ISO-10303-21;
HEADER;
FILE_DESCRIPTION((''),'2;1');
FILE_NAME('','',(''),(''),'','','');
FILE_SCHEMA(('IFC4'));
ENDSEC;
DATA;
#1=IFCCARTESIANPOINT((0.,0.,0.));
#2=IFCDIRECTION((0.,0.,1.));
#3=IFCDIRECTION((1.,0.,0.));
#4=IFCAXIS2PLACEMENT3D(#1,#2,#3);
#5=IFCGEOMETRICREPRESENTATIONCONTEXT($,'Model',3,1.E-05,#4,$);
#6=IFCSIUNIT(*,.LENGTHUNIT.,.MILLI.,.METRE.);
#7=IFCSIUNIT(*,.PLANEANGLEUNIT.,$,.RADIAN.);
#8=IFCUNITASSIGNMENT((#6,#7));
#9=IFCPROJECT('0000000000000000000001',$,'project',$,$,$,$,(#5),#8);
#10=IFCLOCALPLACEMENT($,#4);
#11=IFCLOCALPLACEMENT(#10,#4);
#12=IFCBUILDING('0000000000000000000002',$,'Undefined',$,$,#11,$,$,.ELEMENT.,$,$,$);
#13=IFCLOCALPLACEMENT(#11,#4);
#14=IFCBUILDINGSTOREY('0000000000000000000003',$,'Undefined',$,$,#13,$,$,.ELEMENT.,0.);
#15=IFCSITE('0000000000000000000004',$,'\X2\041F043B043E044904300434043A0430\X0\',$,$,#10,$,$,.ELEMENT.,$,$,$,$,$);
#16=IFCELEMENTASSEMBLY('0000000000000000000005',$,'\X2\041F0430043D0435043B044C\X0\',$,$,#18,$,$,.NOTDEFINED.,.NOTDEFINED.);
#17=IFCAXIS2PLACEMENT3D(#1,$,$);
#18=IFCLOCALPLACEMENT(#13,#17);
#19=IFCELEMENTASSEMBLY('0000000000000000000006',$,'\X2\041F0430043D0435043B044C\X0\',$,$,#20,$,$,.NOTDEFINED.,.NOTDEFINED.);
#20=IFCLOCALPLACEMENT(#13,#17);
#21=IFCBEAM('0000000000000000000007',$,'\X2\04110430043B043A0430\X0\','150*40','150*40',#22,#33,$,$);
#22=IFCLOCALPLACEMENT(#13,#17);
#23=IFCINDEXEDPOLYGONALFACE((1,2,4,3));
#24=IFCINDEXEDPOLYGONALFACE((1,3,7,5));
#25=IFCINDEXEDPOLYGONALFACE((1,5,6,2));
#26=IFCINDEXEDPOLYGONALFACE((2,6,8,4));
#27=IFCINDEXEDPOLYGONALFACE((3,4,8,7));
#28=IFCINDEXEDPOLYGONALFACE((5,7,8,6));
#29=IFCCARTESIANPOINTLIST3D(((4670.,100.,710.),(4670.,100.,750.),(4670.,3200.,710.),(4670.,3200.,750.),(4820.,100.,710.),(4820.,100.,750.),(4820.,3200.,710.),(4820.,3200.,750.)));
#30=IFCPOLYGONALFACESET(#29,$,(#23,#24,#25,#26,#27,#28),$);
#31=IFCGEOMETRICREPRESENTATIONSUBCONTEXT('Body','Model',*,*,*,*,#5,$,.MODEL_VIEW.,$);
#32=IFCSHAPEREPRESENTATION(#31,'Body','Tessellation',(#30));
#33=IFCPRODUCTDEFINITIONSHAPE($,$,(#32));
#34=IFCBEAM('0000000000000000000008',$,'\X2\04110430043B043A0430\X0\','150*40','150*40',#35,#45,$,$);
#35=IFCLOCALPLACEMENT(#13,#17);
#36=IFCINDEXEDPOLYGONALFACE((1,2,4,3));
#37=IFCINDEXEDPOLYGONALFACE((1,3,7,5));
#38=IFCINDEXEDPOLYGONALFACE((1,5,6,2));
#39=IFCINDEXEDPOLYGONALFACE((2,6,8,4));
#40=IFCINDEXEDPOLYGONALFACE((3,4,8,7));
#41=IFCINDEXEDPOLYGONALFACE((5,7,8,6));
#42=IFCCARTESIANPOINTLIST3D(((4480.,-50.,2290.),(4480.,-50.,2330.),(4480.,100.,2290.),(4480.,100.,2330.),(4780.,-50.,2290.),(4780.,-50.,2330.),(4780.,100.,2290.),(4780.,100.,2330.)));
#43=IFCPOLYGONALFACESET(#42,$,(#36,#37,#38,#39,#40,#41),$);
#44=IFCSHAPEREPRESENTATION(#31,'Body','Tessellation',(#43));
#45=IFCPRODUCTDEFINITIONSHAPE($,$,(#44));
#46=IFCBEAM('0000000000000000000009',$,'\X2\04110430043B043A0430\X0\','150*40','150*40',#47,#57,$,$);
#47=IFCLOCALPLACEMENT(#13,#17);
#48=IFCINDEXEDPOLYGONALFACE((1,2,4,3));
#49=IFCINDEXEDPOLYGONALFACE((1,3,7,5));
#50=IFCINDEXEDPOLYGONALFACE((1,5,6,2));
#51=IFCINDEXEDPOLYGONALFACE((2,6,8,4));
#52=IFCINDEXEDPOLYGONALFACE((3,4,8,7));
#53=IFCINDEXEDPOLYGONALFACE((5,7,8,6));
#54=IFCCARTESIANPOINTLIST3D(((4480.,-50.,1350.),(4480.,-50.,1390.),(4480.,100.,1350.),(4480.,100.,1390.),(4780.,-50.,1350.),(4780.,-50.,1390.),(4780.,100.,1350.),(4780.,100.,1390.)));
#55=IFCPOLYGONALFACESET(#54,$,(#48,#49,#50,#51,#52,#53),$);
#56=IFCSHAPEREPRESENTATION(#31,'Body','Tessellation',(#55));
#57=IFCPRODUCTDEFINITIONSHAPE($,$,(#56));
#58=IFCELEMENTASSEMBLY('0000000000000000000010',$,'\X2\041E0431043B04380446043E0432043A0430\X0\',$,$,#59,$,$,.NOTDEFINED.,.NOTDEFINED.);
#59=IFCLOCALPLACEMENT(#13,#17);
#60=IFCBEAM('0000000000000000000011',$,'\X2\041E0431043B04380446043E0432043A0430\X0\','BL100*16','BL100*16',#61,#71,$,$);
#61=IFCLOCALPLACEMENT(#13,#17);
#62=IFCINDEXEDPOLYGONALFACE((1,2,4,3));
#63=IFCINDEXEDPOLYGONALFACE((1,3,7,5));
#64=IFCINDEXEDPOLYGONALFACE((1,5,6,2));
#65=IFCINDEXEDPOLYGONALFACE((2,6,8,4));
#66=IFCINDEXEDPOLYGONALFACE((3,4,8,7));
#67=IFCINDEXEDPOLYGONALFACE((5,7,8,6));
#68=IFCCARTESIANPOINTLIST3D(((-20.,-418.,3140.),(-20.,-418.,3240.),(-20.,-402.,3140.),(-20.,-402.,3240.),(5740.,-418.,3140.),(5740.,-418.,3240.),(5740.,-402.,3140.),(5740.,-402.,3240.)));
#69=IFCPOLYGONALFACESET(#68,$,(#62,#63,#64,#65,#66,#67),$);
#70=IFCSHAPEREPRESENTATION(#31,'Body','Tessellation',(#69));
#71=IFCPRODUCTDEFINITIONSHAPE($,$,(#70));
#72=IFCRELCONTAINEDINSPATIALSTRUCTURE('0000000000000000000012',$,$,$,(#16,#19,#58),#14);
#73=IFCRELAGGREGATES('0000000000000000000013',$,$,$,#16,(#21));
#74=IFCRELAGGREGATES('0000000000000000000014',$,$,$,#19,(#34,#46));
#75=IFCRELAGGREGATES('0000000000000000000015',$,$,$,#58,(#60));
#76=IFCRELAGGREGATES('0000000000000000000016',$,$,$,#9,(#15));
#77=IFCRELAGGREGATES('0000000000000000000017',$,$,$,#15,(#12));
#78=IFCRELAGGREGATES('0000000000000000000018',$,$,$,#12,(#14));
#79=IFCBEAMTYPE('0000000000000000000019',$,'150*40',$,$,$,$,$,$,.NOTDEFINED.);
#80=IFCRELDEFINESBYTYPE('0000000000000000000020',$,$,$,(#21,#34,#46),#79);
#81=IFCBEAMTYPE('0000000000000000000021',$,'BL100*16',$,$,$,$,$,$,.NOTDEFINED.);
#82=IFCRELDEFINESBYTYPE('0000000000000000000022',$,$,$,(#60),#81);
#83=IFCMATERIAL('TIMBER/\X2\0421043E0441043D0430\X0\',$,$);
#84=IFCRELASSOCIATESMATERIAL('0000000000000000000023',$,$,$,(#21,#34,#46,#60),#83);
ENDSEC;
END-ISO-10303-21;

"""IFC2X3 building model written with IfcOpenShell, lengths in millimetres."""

from ifc_helpers import new_model, si_unit, frame, origin_with_axes, origin_2d_with_axis, place, context, subcontext, project, spatial, rectangle, extrude, material, type_object, element, aggregate, save


model = new_model("IFC2X3")

# Units and contexts
model_context = context("Model", 3, precision=1e-05, world=origin_with_axes())
body_context = subcontext(model_context, "Body", "Model", "MODEL_VIEW")
ifc_project = project(units=[si_unit("LENGTHUNIT", "METRE", prefix="MILLI"), si_unit("PLANEANGLEUNIT", "RADIAN")], contexts=[model_context])

# Site, building, storey
site_placement = place(None, origin_with_axes())
site = spatial("IfcSite", under=ifc_project, at=site_placement, Name="Площадка", CompositionType="ELEMENT")
building_placement = place(site_placement, origin_with_axes())
building = spatial("IfcBuilding", under=site, at=building_placement, Name="Undefined", CompositionType="ELEMENT")
storey_placement = place(building_placement, origin_with_axes())
storey = spatial("IfcBuildingStorey", under=building, at=storey_placement, Name="Undefined", CompositionType="ELEMENT", Elevation=0.0)

# Element assembly
ifc_material = material(Name="TIMBER/Сосна")
assembly_1_placement = place(storey_placement, origin_with_axes())
assembly_1 = element("IfcElementAssembly", 1, at=assembly_1_placement, inside=storey, Name="Панель", AssemblyPlace="NOTDEFINED", PredefinedType="NOTDEFINED")

# Element assembly
assembly_2_placement = place(storey_placement, origin_with_axes())
assembly_2 = element("IfcElementAssembly", 2, at=assembly_2_placement, inside=storey, Name="Панель", AssemblyPlace="NOTDEFINED", PredefinedType="NOTDEFINED")

# Shared definitions
beam_type_1 = type_object("IfcBeamType", Name="150*40", PredefinedType="NOTDEFINED")

# Beams
beam_1_placement = place(assembly_1_placement, frame((4745.0, 100.0, 730.0), z_axis=(-1.0, 0.0, 0.0), x_axis=(0.0, 1.0, 0.0)))
beam_1 = element("IfcBeam", 3, at=beam_1_placement, type_object=beam_type_1, material=ifc_material, Name="Балка", Description="150*40", ObjectType="150*40", context=body_context, shape_type="SweptSolid", body=[
    extrude(rectangle(XDim=40.0, YDim=150.0, at=origin_2d_with_axis()), frame((3100.0, 0.0, 0.0), z_axis=(-1.0, 0.0, 0.0), x_axis=(0.0, -1.0, 0.0)), (0.0, 0.0, 1.0), 3100.0),
])
aggregate(assembly_1, [beam_1])
beam_2_placement = place(assembly_2_placement, frame((4480.0, 25.0, 2310.0), z_axis=(0.0, 1.0, 0.0), x_axis=(1.0, 0.0, 0.0)))
beam_2 = element("IfcBeam", 4, at=beam_2_placement, type_object=beam_type_1, material=ifc_material, Name="Балка", Description="150*40", ObjectType="150*40", context=body_context, shape_type="SweptSolid", body=[
    extrude(rectangle(XDim=40.0, YDim=150.0, at=origin_2d_with_axis()), frame((300.0, 0.0, 0.0), z_axis=(-1.0, 0.0, 0.0), x_axis=(0.0, -1.0, 0.0)), (0.0, 0.0, 1.0), 300.0),
])
beam_3_placement = place(assembly_2_placement, frame((4480.0, 25.0, 1370.0), z_axis=(0.0, 1.0, 0.0), x_axis=(1.0, 0.0, 0.0)))
beam_3 = element("IfcBeam", 5, at=beam_3_placement, type_object=beam_type_1, material=ifc_material, Name="Балка", Description="150*40", ObjectType="150*40", context=body_context, shape_type="SweptSolid", body=[
    extrude(rectangle(XDim=40.0, YDim=150.0, at=origin_2d_with_axis()), frame((300.0, 0.0, 0.0), z_axis=(-1.0, 0.0, 0.0), x_axis=(0.0, -1.0, 0.0)), (0.0, 0.0, 1.0), 300.0),
])
aggregate(assembly_2, [beam_2, beam_3])

# Element assembly, beam
assembly_3_placement = place(storey_placement, origin_with_axes())
assembly_3 = element("IfcElementAssembly", 6, at=assembly_3_placement, inside=storey, Name="Облицовка", AssemblyPlace="NOTDEFINED", PredefinedType="NOTDEFINED")
beam_type_2 = type_object("IfcBeamType", Name="BL100*16", PredefinedType="NOTDEFINED")
beam_4_placement = place(assembly_3_placement, frame((5740.0, -410.0, 3190.0), z_axis=(0.0, 0.0, -1.0), x_axis=(-1.0, 0.0, 0.0)))
beam_4 = element("IfcBeam", 7, at=beam_4_placement, type_object=beam_type_2, material=ifc_material, Name="Облицовка", Description="BL100*16", ObjectType="BL100*16", context=body_context, shape_type="SweptSolid", body=[
    extrude(rectangle(XDim=16.0, YDim=100.0, at=origin_2d_with_axis()), frame((5760.0, 0.0, 0.0), z_axis=(-1.0, 0.0, 0.0), x_axis=(0.0, -1.0, 0.0)), (0.0, 0.0, 1.0), 5760.0),
])
aggregate(assembly_3, [beam_4])

save(model, "model.ifc")
